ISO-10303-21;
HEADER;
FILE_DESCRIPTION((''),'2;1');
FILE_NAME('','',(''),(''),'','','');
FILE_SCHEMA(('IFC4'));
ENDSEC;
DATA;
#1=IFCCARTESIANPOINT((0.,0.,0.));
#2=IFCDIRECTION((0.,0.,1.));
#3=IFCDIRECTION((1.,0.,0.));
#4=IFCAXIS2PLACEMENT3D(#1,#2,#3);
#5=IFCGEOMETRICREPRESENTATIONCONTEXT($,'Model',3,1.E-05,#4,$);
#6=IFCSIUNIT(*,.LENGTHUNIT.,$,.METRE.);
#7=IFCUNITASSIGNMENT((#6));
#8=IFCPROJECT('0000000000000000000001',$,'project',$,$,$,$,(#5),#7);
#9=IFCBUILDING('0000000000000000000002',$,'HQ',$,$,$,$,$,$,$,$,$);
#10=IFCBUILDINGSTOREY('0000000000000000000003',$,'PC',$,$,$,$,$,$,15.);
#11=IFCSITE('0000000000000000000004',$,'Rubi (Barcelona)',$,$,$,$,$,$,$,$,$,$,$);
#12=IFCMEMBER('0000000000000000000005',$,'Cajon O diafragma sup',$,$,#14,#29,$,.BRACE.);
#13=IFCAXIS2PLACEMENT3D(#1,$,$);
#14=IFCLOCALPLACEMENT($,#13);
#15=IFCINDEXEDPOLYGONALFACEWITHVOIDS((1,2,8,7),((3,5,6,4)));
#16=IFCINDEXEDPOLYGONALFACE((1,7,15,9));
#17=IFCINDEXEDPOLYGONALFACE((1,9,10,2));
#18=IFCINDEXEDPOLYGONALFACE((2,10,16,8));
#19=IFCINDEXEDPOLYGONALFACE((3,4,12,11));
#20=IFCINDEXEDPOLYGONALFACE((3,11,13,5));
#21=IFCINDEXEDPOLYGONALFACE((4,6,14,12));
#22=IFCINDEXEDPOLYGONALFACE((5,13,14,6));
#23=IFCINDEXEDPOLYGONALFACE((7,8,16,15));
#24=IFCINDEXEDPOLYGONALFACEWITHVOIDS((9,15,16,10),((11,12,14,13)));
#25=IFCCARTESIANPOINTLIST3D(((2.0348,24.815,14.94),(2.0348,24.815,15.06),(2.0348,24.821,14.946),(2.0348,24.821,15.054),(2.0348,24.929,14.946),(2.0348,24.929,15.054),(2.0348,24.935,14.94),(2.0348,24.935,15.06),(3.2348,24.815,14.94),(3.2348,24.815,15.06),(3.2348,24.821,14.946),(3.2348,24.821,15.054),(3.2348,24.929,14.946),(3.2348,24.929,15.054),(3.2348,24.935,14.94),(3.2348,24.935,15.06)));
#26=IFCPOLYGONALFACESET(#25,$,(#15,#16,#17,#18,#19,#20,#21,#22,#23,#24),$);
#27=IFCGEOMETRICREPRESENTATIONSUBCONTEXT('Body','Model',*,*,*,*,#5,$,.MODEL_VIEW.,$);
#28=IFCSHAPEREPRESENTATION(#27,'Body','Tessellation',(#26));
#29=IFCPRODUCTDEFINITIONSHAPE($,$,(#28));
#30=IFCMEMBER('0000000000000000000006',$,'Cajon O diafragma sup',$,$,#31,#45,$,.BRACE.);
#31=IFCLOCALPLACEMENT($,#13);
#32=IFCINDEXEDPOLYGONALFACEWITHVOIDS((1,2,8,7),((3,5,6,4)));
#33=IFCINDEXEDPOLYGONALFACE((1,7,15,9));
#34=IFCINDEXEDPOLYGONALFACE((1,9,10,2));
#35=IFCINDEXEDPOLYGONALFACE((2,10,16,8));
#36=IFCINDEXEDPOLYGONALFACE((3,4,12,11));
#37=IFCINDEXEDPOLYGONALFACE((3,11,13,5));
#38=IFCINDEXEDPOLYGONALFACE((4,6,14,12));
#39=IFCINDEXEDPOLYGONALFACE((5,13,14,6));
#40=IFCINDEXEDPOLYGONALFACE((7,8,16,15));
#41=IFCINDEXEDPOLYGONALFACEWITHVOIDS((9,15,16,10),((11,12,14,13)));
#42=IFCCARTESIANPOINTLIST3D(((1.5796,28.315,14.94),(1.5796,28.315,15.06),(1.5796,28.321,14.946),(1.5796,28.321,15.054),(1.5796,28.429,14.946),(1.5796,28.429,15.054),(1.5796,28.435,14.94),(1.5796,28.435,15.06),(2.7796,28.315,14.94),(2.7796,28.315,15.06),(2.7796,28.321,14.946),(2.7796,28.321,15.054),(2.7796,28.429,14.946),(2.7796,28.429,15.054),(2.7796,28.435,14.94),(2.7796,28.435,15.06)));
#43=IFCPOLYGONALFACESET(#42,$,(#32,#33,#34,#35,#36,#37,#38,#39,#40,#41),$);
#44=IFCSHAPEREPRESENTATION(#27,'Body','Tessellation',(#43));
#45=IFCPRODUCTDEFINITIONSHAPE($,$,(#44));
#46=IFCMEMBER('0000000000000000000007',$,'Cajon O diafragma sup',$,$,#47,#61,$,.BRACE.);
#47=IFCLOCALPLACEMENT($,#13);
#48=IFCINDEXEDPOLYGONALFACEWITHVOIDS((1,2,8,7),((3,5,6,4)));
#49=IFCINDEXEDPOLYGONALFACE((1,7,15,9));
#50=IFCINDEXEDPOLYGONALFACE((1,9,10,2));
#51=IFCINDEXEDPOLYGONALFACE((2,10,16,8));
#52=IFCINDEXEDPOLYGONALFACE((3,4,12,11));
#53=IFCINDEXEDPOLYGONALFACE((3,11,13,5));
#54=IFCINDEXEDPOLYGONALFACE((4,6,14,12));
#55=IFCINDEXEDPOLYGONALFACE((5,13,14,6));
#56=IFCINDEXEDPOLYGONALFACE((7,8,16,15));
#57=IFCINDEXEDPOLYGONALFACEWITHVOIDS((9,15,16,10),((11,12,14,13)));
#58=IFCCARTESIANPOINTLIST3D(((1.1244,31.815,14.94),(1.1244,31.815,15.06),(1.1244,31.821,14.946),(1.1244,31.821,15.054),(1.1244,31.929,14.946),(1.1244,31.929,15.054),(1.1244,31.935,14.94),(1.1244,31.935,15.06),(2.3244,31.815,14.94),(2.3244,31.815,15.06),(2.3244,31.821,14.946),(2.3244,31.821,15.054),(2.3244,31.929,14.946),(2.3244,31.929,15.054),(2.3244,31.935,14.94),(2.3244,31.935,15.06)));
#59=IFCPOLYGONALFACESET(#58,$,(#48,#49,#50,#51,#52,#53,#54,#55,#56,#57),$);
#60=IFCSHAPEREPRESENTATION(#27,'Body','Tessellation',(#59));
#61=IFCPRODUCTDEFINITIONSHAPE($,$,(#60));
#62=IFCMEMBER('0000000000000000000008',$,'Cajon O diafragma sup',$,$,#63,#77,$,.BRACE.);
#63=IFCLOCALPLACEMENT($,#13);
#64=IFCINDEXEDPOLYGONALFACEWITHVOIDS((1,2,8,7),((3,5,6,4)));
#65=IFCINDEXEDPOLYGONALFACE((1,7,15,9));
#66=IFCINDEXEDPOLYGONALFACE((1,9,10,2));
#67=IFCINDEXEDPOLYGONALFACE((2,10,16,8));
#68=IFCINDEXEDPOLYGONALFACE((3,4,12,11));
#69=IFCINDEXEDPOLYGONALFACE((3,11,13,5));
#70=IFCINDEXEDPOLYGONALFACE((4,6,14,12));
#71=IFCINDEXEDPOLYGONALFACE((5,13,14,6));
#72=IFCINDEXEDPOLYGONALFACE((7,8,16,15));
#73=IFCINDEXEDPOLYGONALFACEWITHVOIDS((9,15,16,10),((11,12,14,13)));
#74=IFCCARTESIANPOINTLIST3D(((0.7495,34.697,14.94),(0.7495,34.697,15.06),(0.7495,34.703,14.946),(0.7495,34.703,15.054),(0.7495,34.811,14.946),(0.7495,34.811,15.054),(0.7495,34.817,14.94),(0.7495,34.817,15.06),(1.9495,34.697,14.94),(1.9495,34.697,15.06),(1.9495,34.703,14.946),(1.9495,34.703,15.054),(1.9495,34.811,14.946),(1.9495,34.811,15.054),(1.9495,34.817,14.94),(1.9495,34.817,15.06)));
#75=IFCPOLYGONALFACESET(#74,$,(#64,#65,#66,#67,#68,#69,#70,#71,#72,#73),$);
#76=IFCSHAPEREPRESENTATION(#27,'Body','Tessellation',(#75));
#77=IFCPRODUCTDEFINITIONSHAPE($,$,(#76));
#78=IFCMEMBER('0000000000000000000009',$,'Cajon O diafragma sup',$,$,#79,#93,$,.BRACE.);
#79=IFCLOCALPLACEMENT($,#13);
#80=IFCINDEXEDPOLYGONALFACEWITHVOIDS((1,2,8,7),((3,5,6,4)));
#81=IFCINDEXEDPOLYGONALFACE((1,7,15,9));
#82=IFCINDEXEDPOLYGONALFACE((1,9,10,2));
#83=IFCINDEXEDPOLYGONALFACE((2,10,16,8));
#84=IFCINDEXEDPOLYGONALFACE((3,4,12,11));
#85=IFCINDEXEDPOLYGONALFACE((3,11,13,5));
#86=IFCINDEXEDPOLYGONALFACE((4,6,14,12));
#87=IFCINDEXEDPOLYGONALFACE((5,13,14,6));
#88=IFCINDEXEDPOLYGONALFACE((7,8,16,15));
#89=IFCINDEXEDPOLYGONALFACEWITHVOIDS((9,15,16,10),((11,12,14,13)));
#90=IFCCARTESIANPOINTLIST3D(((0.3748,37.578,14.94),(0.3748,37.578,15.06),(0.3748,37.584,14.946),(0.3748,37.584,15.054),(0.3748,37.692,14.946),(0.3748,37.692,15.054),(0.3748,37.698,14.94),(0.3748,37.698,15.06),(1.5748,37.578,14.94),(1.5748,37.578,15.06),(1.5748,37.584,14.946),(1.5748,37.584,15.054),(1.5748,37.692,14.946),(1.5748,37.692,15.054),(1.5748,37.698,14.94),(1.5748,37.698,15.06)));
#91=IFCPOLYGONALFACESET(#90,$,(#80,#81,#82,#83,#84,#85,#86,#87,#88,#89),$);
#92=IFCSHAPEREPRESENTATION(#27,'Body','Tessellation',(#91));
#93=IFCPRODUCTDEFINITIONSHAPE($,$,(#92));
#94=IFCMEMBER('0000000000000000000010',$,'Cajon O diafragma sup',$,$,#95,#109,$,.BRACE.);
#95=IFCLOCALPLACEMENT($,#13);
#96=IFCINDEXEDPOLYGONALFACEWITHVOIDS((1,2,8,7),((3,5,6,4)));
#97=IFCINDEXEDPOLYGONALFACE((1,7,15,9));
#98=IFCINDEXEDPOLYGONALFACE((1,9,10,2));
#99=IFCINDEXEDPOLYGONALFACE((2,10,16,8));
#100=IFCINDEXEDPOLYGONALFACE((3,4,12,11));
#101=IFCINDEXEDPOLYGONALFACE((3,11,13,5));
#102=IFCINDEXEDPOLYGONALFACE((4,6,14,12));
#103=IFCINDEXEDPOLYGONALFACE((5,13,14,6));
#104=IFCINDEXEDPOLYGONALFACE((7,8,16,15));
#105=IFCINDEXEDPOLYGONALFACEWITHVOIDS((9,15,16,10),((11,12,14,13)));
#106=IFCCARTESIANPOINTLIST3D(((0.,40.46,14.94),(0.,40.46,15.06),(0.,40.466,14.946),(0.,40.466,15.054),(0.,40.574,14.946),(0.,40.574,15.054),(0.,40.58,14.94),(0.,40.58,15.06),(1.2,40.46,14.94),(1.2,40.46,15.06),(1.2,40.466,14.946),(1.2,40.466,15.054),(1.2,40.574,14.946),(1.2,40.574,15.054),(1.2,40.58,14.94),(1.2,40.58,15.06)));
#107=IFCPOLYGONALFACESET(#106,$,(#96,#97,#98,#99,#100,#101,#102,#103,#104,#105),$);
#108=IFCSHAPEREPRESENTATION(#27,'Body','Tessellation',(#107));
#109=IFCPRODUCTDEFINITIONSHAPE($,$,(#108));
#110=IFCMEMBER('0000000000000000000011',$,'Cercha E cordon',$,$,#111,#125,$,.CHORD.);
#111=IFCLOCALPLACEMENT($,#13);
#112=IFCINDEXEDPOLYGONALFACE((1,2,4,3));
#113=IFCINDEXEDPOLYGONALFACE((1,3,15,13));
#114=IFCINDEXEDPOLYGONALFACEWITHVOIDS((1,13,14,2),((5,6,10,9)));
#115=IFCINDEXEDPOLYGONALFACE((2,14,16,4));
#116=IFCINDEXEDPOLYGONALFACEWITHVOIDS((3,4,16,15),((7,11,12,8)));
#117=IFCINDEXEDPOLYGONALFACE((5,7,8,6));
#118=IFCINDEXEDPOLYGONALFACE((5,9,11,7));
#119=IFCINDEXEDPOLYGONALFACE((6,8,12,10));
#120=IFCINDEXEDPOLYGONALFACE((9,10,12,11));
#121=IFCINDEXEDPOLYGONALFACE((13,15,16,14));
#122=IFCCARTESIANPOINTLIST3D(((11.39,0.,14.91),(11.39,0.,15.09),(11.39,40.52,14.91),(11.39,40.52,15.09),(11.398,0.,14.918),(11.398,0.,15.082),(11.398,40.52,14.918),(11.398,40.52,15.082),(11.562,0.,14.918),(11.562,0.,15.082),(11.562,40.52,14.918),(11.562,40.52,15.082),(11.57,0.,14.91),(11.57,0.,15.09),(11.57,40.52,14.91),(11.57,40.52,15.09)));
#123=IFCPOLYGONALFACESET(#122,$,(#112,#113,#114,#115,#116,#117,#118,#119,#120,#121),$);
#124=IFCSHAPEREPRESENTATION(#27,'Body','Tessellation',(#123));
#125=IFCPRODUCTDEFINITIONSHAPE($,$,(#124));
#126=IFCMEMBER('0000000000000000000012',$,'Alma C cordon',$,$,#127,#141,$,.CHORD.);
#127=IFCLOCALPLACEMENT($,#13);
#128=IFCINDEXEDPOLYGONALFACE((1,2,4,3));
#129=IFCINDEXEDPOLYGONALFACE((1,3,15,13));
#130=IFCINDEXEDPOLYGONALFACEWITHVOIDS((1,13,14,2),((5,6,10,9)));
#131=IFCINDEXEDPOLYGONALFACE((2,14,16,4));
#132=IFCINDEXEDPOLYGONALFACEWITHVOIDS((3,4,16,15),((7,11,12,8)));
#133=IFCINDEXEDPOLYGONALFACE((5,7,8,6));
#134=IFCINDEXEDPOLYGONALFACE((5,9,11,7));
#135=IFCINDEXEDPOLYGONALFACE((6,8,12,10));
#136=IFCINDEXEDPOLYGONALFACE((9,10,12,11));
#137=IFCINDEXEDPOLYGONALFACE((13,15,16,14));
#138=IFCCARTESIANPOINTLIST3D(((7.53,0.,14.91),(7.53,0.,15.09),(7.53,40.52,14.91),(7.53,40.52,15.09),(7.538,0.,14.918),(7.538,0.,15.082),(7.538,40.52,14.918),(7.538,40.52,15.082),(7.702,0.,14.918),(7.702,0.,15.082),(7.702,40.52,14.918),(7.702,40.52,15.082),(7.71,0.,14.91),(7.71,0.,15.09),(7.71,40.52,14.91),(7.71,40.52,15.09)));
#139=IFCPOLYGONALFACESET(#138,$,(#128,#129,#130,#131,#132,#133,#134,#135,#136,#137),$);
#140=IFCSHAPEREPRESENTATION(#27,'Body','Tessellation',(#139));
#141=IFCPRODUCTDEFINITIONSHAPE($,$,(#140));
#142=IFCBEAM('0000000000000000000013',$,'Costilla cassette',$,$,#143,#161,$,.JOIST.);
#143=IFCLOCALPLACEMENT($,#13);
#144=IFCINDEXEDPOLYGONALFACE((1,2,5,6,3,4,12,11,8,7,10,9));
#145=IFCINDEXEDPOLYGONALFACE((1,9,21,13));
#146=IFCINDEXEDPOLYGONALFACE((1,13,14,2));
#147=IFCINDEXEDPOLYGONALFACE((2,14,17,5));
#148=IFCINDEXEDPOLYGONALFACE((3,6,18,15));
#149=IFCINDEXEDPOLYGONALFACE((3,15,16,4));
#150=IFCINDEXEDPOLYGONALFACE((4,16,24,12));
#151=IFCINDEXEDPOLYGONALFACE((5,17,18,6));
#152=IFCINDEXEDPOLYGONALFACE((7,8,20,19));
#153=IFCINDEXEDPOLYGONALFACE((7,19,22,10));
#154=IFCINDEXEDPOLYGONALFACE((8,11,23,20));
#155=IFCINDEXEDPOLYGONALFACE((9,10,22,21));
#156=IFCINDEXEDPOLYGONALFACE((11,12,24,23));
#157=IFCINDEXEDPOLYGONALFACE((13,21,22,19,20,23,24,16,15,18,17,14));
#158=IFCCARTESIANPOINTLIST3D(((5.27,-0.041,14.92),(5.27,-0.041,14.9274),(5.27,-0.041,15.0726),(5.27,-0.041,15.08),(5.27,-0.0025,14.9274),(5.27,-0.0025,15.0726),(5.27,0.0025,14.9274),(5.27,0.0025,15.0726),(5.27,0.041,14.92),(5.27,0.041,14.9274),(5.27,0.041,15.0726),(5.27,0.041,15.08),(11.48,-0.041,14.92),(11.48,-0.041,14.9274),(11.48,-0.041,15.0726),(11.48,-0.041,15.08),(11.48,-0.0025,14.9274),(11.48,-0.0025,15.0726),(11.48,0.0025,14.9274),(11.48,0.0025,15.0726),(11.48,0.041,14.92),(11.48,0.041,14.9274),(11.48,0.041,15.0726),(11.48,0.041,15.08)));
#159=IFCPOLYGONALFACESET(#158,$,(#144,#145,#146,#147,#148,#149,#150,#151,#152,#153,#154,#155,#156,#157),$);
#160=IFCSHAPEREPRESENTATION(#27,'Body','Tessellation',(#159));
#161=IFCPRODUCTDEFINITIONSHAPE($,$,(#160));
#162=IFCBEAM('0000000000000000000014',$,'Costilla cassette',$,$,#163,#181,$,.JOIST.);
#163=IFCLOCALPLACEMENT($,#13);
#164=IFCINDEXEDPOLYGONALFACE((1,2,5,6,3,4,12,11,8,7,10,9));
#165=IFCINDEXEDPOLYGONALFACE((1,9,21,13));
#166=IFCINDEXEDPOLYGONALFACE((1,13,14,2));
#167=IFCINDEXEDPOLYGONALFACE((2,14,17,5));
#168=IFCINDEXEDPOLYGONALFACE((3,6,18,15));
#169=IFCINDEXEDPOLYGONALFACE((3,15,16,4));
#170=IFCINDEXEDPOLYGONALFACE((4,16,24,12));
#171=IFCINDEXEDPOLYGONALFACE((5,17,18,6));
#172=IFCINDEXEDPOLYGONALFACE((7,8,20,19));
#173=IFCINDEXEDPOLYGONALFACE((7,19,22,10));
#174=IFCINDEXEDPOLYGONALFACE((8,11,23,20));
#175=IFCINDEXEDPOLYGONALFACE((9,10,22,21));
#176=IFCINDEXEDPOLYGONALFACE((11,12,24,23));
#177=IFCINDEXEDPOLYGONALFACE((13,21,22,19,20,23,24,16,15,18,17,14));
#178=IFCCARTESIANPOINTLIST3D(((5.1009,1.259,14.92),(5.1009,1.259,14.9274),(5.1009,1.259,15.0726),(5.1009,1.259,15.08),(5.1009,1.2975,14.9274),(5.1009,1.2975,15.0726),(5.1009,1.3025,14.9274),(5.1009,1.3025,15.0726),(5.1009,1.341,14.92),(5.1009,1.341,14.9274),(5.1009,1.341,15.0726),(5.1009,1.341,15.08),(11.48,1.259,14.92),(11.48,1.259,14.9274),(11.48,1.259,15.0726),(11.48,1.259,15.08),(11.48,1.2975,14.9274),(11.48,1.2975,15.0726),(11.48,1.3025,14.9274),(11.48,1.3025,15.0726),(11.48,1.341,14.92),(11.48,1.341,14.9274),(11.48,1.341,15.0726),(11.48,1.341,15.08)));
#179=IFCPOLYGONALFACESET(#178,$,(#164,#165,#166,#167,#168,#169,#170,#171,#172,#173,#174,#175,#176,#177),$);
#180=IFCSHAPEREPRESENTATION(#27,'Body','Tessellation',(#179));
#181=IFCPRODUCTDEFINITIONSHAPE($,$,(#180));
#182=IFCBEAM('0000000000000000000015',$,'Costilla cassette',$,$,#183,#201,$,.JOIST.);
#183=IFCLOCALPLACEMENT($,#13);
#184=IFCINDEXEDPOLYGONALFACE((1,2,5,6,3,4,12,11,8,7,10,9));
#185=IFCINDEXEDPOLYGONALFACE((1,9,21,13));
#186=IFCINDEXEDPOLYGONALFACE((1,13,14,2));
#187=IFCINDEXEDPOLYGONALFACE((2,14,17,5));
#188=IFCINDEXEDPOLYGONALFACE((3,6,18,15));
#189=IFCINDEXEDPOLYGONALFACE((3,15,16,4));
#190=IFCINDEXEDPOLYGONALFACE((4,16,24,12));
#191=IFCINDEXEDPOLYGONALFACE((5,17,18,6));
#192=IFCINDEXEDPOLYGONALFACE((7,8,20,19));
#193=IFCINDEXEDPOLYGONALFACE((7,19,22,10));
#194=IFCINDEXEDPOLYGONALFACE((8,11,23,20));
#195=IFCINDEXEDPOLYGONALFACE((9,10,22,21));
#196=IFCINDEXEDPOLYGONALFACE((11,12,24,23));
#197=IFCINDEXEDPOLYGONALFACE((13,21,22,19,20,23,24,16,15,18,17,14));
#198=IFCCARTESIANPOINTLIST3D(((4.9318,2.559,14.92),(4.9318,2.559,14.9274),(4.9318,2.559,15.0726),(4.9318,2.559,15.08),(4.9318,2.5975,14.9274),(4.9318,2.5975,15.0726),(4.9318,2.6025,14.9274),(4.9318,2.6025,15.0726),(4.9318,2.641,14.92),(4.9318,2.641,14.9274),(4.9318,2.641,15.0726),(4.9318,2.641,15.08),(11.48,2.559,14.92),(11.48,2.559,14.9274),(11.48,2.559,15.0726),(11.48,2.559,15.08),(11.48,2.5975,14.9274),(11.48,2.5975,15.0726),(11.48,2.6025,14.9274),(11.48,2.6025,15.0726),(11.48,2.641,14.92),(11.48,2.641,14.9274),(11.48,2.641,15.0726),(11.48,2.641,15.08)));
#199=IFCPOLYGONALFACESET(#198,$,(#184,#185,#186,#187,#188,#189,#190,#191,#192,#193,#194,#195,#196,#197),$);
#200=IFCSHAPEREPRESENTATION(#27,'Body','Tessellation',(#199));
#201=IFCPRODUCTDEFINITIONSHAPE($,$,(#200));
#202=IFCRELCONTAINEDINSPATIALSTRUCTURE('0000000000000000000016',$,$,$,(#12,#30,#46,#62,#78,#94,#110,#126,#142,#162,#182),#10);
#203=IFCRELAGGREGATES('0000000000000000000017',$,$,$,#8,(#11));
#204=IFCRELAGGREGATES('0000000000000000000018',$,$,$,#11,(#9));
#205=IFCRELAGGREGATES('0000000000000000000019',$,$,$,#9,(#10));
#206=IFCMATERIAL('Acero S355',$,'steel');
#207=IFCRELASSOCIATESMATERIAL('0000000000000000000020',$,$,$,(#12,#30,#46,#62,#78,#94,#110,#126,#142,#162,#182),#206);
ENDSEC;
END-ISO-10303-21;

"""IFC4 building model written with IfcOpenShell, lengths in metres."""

from ifc_helpers import new_model, si_unit, frame, origin_with_axes, place, context, subcontext, project, spatial, hollow_rectangle, i_section, extrude, material, element, save


model = new_model("IFC4")

# Units and contexts
model_context = context("Model", 3, precision=1e-05, world=origin_with_axes())
body_context = subcontext(model_context, "Body", "Model", "MODEL_VIEW")
ifc_project = project(units=[si_unit("LENGTHUNIT", "METRE")], contexts=[model_context])

# Site, building, storey
site = spatial("IfcSite", under=ifc_project, Name="Rubi (Barcelona)")
building = spatial("IfcBuilding", under=site, Name="HQ")
storey = spatial("IfcBuildingStorey", under=building, Name="PC", Elevation=15.0)

# Members
ifc_material = material(Name="Acero S355", Category="steel")
member_1_placement = place(None, origin_with_axes())
element("IfcMember", 1, at=member_1_placement, inside=storey, material=ifc_material, Name="Cajon O diafragma sup", PredefinedType="BRACE", context=body_context, shape_type="SweptSolid", body=[
    extrude(hollow_rectangle(XDim=0.12, YDim=0.12, WallThickness=0.006), frame((2.0348, 24.875, 15.0), z_axis=(1.0, 0.0, 0.0), x_axis=(0.0, 1.0, 0.0)), (0.0, 0.0, 1.0), 1.2),
])
member_2_placement = place(None, origin_with_axes())
element("IfcMember", 2, at=member_2_placement, inside=storey, material=ifc_material, Name="Cajon O diafragma sup", PredefinedType="BRACE", context=body_context, shape_type="SweptSolid", body=[
    extrude(hollow_rectangle(XDim=0.12, YDim=0.12, WallThickness=0.006), frame((1.5796, 28.375, 15.0), z_axis=(1.0, 0.0, 0.0), x_axis=(0.0, 1.0, 0.0)), (0.0, 0.0, 1.0), 1.2),
])
member_3_placement = place(None, origin_with_axes())
element("IfcMember", 3, at=member_3_placement, inside=storey, material=ifc_material, Name="Cajon O diafragma sup", PredefinedType="BRACE", context=body_context, shape_type="SweptSolid", body=[
    extrude(hollow_rectangle(XDim=0.12, YDim=0.12, WallThickness=0.006), frame((1.1244, 31.875, 15.0), z_axis=(1.0, 0.0, 0.0), x_axis=(0.0, 1.0, 0.0)), (0.0, 0.0, 1.0), 1.2),
])
member_4_placement = place(None, origin_with_axes())
element("IfcMember", 4, at=member_4_placement, inside=storey, material=ifc_material, Name="Cajon O diafragma sup", PredefinedType="BRACE", context=body_context, shape_type="SweptSolid", body=[
    extrude(hollow_rectangle(XDim=0.12, YDim=0.12, WallThickness=0.006), frame((0.7495, 34.757, 15.0), z_axis=(1.0, 0.0, 0.0), x_axis=(0.0, 1.0, 0.0)), (0.0, 0.0, 1.0), 1.2),
])
member_5_placement = place(None, origin_with_axes())
element("IfcMember", 5, at=member_5_placement, inside=storey, material=ifc_material, Name="Cajon O diafragma sup", PredefinedType="BRACE", context=body_context, shape_type="SweptSolid", body=[
    extrude(hollow_rectangle(XDim=0.12, YDim=0.12, WallThickness=0.006), frame((0.3748, 37.638, 15.0), z_axis=(1.0, 0.0, 0.0), x_axis=(0.0, 1.0, 0.0)), (0.0, 0.0, 1.0), 1.2),
])
member_6_placement = place(None, origin_with_axes())
element("IfcMember", 6, at=member_6_placement, inside=storey, material=ifc_material, Name="Cajon O diafragma sup", PredefinedType="BRACE", context=body_context, shape_type="SweptSolid", body=[
    extrude(hollow_rectangle(XDim=0.12, YDim=0.12, WallThickness=0.006), frame((0.0, 40.52, 15.0), z_axis=(1.0, 0.0, 0.0), x_axis=(0.0, 1.0, 0.0)), (0.0, 0.0, 1.0), 1.2),
])
member_7_placement = place(None, origin_with_axes())
element("IfcMember", 7, at=member_7_placement, inside=storey, material=ifc_material, Name="Cercha E cordon", PredefinedType="CHORD", context=body_context, shape_type="SweptSolid", body=[
    extrude(hollow_rectangle(XDim=0.18, YDim=0.18, WallThickness=0.008), frame((11.48, 0.0, 15.0), z_axis=(0.0, 1.0, 0.0), x_axis=(-1.0, 0.0, 0.0)), (0.0, 0.0, 1.0), 40.52),
])
member_8_placement = place(None, origin_with_axes())
element("IfcMember", 8, at=member_8_placement, inside=storey, material=ifc_material, Name="Alma C cordon", PredefinedType="CHORD", context=body_context, shape_type="SweptSolid", body=[
    extrude(hollow_rectangle(XDim=0.18, YDim=0.18, WallThickness=0.008), frame((7.62, 0.0, 15.0), z_axis=(0.0, 1.0, 0.0), x_axis=(-1.0, 0.0, 0.0)), (0.0, 0.0, 1.0), 40.52),
])

# Beams
beam_1_placement = place(None, origin_with_axes())
element("IfcBeam", 9, at=beam_1_placement, inside=storey, material=ifc_material, Name="Costilla cassette", PredefinedType="JOIST", context=body_context, shape_type="SweptSolid", body=[
    extrude(i_section(OverallWidth=0.082, OverallDepth=0.16, WebThickness=0.005, FlangeThickness=0.0074), frame((5.27, 0.0, 15.0), z_axis=(1.0, 0.0, 0.0), x_axis=(0.0, 1.0, 0.0)), (0.0, 0.0, 1.0), 6.21),
])
beam_2_placement = place(None, origin_with_axes())
element("IfcBeam", 10, at=beam_2_placement, inside=storey, material=ifc_material, Name="Costilla cassette", PredefinedType="JOIST", context=body_context, shape_type="SweptSolid", body=[
    extrude(i_section(OverallWidth=0.082, OverallDepth=0.16, WebThickness=0.005, FlangeThickness=0.0074), frame((5.1009, 1.3, 15.0), z_axis=(1.0, 0.0, 0.0), x_axis=(0.0, 1.0, 0.0)), (0.0, 0.0, 1.0), 6.3791),
])
beam_3_placement = place(None, origin_with_axes())
element("IfcBeam", 11, at=beam_3_placement, inside=storey, material=ifc_material, Name="Costilla cassette", PredefinedType="JOIST", context=body_context, shape_type="SweptSolid", body=[
    extrude(i_section(OverallWidth=0.082, OverallDepth=0.16, WebThickness=0.005, FlangeThickness=0.0074), frame((4.9318, 2.6, 15.0), z_axis=(1.0, 0.0, 0.0), x_axis=(0.0, 1.0, 0.0)), (0.0, 0.0, 1.0), 6.5482),
])

save(model, "model.ifc")
